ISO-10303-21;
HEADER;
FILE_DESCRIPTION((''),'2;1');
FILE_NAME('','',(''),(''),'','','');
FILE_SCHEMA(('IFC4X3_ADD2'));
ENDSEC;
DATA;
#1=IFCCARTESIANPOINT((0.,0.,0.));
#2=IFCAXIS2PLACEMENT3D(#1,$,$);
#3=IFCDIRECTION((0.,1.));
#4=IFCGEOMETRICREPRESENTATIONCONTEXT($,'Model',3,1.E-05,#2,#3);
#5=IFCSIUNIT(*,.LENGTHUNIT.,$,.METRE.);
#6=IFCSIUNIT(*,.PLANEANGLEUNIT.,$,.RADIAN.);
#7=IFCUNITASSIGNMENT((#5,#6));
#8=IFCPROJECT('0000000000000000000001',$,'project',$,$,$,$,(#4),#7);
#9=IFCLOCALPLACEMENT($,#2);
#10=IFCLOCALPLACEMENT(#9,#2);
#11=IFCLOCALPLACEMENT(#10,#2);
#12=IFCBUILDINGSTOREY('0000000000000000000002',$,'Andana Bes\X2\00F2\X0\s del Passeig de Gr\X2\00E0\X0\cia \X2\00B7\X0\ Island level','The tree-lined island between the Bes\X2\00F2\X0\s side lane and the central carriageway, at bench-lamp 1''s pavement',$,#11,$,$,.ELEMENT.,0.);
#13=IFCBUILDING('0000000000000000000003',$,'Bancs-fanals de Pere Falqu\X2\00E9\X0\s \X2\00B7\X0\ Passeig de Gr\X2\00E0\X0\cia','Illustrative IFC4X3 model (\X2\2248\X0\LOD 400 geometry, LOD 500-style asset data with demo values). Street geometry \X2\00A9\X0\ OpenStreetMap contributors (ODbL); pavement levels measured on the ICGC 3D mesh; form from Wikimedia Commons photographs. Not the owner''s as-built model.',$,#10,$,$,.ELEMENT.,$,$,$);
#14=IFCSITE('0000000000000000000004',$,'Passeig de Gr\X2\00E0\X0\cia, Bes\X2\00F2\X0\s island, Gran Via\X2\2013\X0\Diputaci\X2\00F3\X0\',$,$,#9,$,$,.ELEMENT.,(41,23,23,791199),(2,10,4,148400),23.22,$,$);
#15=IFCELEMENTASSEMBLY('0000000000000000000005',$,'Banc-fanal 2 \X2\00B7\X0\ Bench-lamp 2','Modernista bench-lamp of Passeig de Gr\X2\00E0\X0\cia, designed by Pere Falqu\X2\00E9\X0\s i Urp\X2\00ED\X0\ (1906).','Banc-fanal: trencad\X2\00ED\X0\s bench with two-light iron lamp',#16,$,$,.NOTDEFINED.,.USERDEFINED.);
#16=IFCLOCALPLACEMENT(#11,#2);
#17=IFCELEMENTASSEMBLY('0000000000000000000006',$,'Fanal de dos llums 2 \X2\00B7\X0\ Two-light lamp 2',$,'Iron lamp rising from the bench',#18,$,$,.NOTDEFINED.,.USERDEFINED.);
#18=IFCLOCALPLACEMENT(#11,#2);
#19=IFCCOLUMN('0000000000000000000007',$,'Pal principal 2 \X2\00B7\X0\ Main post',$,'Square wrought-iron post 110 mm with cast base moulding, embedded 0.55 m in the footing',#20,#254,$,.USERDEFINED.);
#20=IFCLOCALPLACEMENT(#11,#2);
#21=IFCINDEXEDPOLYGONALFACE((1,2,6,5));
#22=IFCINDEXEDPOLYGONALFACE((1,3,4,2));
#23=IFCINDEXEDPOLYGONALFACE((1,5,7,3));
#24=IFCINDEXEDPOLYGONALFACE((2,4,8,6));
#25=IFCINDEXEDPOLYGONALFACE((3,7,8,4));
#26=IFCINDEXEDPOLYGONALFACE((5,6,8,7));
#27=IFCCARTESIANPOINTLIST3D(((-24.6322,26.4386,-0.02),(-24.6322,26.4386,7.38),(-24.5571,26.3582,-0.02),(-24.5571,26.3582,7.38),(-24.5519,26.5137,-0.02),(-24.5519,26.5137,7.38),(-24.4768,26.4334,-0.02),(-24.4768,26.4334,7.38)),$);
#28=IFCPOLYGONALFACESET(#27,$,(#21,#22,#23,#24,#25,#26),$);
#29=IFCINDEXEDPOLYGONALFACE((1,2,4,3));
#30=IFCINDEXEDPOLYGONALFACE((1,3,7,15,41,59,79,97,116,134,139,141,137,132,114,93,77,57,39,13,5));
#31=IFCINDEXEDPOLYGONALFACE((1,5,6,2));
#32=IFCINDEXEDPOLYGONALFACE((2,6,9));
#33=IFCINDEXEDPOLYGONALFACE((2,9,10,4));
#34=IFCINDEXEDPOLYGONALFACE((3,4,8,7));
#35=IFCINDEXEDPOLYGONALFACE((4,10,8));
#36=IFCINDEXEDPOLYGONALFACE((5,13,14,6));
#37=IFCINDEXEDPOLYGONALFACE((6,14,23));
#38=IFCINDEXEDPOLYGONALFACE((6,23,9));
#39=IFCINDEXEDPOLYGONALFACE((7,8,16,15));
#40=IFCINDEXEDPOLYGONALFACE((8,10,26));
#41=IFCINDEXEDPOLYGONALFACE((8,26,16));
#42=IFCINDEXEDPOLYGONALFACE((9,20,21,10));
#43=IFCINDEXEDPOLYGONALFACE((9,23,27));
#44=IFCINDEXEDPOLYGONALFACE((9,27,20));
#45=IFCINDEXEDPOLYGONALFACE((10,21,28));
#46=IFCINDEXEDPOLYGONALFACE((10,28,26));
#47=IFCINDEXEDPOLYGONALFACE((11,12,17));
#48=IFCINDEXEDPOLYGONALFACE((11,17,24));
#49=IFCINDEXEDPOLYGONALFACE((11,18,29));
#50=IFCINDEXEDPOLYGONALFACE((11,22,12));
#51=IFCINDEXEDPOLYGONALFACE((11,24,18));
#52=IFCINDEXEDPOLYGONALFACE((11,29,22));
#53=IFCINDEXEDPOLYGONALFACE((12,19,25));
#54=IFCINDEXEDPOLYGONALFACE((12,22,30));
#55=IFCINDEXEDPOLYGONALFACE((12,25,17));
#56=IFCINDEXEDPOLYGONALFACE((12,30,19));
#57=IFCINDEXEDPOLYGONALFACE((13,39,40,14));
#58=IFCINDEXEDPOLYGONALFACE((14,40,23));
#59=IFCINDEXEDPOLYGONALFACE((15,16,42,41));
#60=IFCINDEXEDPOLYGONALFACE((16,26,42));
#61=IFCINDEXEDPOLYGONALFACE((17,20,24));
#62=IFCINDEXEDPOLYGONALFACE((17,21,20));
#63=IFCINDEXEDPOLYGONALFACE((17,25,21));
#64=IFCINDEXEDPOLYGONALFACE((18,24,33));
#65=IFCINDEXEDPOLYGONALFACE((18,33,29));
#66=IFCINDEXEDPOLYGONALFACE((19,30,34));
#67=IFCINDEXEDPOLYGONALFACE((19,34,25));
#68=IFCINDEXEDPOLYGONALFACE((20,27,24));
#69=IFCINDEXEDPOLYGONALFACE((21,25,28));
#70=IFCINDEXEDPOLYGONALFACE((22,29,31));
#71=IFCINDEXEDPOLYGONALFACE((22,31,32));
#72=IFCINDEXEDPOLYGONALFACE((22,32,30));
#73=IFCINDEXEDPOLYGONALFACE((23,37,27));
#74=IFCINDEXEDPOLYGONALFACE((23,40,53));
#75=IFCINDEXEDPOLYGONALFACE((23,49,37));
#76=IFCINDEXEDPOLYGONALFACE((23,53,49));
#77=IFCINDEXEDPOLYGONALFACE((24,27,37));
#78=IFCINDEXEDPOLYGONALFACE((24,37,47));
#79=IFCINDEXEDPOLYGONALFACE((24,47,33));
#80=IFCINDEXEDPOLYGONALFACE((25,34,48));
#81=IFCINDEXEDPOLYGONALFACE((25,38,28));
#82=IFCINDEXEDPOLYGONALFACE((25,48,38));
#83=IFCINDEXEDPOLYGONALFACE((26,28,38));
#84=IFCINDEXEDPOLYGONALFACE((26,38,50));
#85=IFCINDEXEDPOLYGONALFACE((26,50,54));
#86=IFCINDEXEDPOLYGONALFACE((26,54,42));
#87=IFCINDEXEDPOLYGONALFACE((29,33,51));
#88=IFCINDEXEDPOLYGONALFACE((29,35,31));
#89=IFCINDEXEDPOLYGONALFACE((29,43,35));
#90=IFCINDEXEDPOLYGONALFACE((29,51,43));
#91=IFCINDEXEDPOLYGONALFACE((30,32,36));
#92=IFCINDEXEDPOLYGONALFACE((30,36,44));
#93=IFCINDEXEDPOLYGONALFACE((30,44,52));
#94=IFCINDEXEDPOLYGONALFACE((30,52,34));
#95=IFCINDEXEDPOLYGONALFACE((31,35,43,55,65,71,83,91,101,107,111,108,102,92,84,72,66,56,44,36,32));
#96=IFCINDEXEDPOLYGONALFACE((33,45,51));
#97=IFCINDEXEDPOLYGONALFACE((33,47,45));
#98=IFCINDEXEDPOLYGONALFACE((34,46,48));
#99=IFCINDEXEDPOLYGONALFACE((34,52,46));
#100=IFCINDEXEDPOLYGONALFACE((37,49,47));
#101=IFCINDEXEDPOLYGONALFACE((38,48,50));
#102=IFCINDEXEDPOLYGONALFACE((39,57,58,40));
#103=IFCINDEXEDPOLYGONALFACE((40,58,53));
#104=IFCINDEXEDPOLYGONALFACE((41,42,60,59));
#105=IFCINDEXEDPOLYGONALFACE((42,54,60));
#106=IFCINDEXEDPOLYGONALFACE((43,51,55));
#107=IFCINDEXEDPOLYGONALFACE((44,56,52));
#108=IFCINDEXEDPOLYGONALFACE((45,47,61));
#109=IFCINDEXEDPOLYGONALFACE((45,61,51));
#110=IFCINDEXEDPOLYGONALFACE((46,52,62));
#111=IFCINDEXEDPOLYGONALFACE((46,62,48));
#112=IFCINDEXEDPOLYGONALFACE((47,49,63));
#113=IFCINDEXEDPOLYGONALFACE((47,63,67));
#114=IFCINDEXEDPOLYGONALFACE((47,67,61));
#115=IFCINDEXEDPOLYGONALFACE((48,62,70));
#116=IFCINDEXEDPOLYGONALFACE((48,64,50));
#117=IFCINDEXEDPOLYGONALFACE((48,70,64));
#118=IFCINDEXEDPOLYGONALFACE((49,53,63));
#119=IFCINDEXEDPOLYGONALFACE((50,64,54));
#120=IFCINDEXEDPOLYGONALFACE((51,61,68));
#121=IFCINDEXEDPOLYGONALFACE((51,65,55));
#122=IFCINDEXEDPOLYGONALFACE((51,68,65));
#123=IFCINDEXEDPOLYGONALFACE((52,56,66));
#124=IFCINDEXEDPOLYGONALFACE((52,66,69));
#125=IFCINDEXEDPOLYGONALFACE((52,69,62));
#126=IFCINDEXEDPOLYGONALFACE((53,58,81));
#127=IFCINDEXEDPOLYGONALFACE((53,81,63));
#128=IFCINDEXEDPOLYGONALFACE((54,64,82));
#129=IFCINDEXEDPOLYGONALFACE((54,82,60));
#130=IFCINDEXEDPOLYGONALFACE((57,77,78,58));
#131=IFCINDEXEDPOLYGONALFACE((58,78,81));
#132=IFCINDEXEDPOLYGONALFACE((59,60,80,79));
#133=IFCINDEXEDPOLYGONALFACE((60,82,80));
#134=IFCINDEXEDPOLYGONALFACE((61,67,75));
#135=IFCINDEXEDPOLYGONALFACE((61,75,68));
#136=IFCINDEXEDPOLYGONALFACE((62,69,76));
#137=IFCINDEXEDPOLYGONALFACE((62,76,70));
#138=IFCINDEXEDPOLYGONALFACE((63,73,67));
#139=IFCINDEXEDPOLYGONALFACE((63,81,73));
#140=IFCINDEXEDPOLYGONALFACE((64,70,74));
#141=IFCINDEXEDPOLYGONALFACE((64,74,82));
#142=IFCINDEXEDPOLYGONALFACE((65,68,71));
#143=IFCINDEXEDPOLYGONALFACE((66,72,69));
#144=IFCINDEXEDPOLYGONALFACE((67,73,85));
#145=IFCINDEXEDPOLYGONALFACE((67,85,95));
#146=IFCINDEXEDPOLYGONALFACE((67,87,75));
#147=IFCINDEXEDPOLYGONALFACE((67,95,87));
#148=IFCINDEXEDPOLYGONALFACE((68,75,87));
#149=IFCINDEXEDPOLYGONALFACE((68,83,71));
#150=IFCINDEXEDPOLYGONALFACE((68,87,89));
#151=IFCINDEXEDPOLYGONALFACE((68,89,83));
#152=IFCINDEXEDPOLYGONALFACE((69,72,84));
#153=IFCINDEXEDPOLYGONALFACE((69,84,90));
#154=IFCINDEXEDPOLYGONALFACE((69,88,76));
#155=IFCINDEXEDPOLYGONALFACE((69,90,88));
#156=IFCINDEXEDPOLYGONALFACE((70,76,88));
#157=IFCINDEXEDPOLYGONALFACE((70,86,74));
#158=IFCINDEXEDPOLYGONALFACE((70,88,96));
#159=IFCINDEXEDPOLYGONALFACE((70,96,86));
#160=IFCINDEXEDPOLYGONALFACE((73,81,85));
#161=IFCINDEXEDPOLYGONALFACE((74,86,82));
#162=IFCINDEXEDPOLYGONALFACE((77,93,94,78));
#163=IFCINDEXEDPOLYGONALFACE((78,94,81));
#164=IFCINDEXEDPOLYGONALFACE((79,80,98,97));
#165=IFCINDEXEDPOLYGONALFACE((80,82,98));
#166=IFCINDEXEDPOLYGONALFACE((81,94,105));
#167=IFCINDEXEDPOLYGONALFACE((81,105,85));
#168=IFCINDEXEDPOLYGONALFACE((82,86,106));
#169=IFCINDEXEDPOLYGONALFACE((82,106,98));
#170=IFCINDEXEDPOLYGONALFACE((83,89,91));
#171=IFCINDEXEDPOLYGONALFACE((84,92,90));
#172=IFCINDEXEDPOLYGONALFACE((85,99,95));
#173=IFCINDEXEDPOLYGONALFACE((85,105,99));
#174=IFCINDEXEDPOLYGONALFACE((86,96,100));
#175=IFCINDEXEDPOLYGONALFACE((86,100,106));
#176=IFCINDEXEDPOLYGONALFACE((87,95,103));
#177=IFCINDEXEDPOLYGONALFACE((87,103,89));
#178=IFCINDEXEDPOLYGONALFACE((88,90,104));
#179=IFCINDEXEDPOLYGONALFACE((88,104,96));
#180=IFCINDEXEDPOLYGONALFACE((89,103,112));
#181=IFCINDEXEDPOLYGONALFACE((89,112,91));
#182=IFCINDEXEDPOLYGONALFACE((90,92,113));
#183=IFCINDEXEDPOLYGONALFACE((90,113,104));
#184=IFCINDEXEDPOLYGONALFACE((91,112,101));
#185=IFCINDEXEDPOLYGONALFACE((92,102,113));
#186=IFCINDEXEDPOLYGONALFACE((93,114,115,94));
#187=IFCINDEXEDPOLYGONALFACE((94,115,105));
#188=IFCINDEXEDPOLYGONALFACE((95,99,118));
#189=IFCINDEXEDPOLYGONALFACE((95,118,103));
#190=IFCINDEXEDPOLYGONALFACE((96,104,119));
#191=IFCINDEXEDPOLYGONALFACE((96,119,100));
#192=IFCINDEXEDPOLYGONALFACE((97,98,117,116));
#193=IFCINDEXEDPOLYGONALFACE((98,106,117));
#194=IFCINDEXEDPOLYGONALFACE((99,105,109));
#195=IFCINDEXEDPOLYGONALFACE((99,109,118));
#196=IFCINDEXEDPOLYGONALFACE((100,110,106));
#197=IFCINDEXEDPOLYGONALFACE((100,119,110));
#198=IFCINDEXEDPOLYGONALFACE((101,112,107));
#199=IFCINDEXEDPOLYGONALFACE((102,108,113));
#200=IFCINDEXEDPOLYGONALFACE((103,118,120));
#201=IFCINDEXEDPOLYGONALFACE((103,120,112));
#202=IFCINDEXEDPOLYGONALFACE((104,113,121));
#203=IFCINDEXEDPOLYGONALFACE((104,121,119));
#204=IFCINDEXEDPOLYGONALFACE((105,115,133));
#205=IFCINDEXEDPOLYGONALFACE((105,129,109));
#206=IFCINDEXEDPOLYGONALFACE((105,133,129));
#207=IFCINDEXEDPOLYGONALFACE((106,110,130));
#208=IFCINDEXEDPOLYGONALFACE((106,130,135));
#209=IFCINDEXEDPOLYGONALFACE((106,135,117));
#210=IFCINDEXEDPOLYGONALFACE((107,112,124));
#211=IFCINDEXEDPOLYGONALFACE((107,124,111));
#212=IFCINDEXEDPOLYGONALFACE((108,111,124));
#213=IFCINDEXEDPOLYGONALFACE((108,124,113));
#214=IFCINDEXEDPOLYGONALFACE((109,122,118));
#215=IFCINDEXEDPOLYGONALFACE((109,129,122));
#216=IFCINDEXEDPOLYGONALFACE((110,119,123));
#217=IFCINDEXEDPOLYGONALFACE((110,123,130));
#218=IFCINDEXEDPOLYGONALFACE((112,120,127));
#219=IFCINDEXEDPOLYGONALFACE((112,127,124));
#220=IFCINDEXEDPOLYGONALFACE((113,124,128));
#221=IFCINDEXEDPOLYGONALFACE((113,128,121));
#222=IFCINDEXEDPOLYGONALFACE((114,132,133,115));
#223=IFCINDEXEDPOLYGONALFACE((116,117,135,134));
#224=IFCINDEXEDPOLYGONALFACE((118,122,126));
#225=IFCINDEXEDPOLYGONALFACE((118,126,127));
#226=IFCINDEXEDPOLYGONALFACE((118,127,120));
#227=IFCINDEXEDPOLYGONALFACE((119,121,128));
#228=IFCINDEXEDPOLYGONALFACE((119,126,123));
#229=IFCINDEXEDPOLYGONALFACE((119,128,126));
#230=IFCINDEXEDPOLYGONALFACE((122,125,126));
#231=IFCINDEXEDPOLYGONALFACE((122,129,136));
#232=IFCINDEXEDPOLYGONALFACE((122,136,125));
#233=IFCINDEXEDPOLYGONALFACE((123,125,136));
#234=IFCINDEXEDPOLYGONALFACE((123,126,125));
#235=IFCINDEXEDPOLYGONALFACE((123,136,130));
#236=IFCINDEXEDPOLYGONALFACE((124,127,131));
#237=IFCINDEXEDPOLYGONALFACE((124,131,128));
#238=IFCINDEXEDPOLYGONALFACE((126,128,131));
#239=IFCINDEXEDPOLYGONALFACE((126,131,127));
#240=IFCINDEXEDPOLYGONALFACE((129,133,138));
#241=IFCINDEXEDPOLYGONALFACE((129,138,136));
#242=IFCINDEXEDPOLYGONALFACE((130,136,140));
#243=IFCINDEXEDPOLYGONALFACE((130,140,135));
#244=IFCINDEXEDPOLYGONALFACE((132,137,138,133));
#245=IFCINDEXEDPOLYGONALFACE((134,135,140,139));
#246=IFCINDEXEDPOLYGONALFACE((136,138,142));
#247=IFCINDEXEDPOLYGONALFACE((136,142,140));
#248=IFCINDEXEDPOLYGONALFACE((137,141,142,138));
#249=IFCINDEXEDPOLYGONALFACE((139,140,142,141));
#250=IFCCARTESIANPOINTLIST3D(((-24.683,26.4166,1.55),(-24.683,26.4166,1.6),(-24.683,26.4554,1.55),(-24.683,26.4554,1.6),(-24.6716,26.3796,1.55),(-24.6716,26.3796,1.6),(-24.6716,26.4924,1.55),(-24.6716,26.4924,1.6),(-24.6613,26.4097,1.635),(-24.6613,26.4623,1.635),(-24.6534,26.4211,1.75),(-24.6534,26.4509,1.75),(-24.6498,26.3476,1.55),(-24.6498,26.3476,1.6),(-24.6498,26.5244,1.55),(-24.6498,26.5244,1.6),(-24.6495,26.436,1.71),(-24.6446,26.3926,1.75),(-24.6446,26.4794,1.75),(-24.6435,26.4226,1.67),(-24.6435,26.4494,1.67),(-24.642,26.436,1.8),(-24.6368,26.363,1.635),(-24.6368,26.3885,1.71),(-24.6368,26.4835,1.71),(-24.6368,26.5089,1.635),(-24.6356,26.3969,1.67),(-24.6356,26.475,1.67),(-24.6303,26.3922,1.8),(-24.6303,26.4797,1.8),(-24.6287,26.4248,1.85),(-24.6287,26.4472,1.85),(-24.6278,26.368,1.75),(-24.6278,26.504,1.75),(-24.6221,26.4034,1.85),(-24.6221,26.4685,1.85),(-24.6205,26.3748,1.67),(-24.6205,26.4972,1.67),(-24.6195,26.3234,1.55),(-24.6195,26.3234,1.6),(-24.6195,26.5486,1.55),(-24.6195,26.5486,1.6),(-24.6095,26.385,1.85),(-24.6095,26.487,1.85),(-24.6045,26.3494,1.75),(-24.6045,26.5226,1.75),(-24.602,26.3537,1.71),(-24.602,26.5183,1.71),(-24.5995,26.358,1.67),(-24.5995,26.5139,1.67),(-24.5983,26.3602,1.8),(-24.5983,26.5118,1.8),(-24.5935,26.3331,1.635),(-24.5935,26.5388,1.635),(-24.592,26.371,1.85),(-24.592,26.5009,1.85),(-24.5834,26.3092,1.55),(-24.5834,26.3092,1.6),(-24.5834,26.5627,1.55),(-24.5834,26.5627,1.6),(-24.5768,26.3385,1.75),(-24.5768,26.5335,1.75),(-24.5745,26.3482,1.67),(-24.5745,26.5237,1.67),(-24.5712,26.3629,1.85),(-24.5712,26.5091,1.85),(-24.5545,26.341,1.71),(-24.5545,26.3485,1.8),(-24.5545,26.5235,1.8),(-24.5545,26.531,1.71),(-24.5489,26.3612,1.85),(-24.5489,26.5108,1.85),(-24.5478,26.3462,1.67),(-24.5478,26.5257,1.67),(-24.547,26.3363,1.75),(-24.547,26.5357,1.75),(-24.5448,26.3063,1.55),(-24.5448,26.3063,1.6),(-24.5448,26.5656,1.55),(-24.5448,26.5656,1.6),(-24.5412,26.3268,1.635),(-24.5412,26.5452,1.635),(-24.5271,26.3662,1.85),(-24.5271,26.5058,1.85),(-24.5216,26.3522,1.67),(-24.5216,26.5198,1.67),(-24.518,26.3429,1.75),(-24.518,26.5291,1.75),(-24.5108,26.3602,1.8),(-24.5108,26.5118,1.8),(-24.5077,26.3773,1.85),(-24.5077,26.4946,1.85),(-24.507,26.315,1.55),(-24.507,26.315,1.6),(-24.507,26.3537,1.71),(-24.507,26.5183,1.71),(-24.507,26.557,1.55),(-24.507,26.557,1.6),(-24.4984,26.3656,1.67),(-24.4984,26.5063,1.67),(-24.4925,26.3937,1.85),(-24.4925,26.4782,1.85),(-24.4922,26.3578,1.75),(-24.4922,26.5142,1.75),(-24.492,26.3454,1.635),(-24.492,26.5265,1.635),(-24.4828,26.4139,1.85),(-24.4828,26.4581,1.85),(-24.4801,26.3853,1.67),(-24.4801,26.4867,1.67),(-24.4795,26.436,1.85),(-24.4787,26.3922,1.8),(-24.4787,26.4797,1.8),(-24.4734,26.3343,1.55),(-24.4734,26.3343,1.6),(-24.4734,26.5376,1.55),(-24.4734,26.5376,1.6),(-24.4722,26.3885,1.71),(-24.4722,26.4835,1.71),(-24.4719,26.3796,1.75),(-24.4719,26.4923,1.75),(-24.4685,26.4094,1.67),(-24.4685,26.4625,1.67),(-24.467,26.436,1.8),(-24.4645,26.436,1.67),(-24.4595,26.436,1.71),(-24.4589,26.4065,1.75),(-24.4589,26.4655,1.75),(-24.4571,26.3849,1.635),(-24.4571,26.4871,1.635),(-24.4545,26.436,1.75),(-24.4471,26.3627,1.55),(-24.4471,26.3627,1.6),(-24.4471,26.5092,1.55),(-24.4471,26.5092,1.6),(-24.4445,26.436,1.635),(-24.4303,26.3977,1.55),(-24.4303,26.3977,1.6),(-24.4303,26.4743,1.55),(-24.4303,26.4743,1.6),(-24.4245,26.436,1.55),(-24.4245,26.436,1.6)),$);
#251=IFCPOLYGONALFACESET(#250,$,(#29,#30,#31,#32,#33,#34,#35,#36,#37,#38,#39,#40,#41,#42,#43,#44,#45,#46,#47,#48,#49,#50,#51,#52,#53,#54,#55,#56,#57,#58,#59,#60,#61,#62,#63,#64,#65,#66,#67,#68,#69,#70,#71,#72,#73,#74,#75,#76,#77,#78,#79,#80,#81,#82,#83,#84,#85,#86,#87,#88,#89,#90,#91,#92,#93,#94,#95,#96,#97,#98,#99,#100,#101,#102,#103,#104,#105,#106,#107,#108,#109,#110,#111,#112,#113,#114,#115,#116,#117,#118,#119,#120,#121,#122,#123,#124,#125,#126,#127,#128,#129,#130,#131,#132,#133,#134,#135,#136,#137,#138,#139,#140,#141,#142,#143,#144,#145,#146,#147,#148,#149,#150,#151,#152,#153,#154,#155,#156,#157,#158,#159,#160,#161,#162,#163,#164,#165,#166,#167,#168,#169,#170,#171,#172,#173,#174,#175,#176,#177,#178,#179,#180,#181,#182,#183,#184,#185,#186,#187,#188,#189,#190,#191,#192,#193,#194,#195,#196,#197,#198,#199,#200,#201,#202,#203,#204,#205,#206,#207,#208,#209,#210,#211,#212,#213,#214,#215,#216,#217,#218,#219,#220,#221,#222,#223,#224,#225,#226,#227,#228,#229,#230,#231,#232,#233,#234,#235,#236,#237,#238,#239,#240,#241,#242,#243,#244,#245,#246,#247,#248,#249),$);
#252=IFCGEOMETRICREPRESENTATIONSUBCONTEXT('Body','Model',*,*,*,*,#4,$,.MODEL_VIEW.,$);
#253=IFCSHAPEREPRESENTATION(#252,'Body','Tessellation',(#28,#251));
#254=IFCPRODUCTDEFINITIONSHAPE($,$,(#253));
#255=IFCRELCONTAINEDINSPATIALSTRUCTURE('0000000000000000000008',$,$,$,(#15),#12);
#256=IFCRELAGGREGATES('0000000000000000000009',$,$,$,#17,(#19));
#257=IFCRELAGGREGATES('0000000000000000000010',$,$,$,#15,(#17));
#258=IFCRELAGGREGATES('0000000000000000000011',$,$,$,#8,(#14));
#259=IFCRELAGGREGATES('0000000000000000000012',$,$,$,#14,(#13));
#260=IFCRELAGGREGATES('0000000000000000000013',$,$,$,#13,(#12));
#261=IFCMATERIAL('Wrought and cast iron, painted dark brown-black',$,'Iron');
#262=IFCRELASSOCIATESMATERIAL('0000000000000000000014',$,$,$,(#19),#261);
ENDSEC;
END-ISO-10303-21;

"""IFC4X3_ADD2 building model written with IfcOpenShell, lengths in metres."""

from ifc_helpers import new_model, entity, si_unit, direction, frame, frame_2d, origin, place, context, subcontext, project, spatial, rectangle, extrude, material, element, aggregate, save


model = new_model("IFC4X3_ADD2")

# Units and contexts
model_context = context("Model", 3, precision=1e-05, world=origin(), true_north=direction((0.0, 1.0)))
body_context = subcontext(model_context, "Body", "Model", "MODEL_VIEW")
ifc_project = project(units=[si_unit("LENGTHUNIT", "METRE"), si_unit("PLANEANGLEUNIT", "RADIAN")], contexts=[model_context])

# Site, building, storey
site_placement = place(None, origin())
site = spatial("IfcSite", under=ifc_project, at=site_placement, Name="Passeig de Gràcia, Besòs island, Gran Via–Diputació", CompositionType="ELEMENT", RefLatitude=(41, 23, 23, 791199), RefLongitude=(2, 10, 4, 148400), RefElevation=23.22)
building_placement = place(site_placement, origin())
building = spatial("IfcBuilding", under=site, at=building_placement, Name="Bancs-fanals de Pere Falqués · Passeig de Gràcia", Description="Illustrative IFC4X3 model (≈LOD 400 geometry, LOD 500-style asset data with demo values). Street geometry © OpenStreetMap contributors (ODbL); pavement levels measured on the ICGC 3D mesh; form from Wikimedia Commons photographs. Not the owner's as-built model.", CompositionType="ELEMENT")
storey_placement = place(building_placement, origin())
storey = spatial("IfcBuildingStorey", under=building, at=storey_placement, Name="Andana Besòs del Passeig de Gràcia · Island level", Description="The tree-lined island between the Besòs side lane and the central carriageway, at bench-lamp 1's pavement", CompositionType="ELEMENT", Elevation=0.0)

# Element assembly
assembly_1_placement = place(building_placement, origin())
assembly_1 = element("IfcElementAssembly", 1, at=assembly_1_placement, inside=storey, Name="Banc-fanal 2 · Bench-lamp 2", Description="Modernista bench-lamp of Passeig de Gràcia, designed by Pere Falqués i Urpí (1906).", ObjectType="Banc-fanal: trencadís bench with two-light iron lamp", AssemblyPlace="NOTDEFINED", PredefinedType="USERDEFINED")

# Element assembly, column
ifc_material_1 = material(Name="Wrought and cast iron, painted dark brown-black", Category="Iron")
assembly_2_placement = place(building_placement, origin())
assembly_2 = element("IfcElementAssembly", 2, at=assembly_2_placement, Name="Fanal de dos llums 2 · Two-light lamp 2", ObjectType="Iron lamp rising from the bench", AssemblyPlace="NOTDEFINED", PredefinedType="USERDEFINED")
column_1_placement = place(building_placement, origin())
column_1 = element("IfcColumn", 3, at=column_1_placement, material=ifc_material_1, Name="Pal principal 2 · Main post", ObjectType="Square wrought-iron post 110 mm with cast base moulding, embedded 0.55 m in the footing", PredefinedType="USERDEFINED", context=body_context, shape_type="SweptSolid", body=[
    extrude(rectangle(XDim=0.11, YDim=0.11, at=frame_2d((0.0, 0.0), x_axis=(-0.683274, 0.730162))), frame((-24.5545, 26.436, -0.02)), (0.0, 0.0, 1.0), 7.4),
    entity("IfcRevolvedAreaSolid", entity("IfcArbitraryClosedProfileDef", "AREA", None, entity("IfcPolyline", [entity("IfcCartesianPoint", [0.0, 0.0]), entity("IfcCartesianPoint", [0.13, 0.0]), entity("IfcCartesianPoint", [0.13, 0.05]), entity("IfcCartesianPoint", [0.09, 0.12]), entity("IfcCartesianPoint", [0.1, 0.2]), entity("IfcCartesianPoint", [0.075, 0.3]), entity("IfcCartesianPoint", [0.0, 0.3]), entity("IfcCartesianPoint", [0.0, 0.0])])), entity("IfcAxis2Placement3D", entity("IfcCartesianPoint", [-24.5545, 26.436, 1.55]), entity("IfcDirection", [0.0, -1.0, 0.0]), entity("IfcDirection", [1.0, 0.0, 0.0])), entity("IfcAxis1Placement", entity("IfcCartesianPoint", [0.0, 0.0, 0.0]), entity("IfcDirection", [0.0, 1.0, 0.0])), 6.283185),
])

aggregate(assembly_2, [column_1])

aggregate(assembly_1, [assembly_2])

save(model, "model.ifc")
